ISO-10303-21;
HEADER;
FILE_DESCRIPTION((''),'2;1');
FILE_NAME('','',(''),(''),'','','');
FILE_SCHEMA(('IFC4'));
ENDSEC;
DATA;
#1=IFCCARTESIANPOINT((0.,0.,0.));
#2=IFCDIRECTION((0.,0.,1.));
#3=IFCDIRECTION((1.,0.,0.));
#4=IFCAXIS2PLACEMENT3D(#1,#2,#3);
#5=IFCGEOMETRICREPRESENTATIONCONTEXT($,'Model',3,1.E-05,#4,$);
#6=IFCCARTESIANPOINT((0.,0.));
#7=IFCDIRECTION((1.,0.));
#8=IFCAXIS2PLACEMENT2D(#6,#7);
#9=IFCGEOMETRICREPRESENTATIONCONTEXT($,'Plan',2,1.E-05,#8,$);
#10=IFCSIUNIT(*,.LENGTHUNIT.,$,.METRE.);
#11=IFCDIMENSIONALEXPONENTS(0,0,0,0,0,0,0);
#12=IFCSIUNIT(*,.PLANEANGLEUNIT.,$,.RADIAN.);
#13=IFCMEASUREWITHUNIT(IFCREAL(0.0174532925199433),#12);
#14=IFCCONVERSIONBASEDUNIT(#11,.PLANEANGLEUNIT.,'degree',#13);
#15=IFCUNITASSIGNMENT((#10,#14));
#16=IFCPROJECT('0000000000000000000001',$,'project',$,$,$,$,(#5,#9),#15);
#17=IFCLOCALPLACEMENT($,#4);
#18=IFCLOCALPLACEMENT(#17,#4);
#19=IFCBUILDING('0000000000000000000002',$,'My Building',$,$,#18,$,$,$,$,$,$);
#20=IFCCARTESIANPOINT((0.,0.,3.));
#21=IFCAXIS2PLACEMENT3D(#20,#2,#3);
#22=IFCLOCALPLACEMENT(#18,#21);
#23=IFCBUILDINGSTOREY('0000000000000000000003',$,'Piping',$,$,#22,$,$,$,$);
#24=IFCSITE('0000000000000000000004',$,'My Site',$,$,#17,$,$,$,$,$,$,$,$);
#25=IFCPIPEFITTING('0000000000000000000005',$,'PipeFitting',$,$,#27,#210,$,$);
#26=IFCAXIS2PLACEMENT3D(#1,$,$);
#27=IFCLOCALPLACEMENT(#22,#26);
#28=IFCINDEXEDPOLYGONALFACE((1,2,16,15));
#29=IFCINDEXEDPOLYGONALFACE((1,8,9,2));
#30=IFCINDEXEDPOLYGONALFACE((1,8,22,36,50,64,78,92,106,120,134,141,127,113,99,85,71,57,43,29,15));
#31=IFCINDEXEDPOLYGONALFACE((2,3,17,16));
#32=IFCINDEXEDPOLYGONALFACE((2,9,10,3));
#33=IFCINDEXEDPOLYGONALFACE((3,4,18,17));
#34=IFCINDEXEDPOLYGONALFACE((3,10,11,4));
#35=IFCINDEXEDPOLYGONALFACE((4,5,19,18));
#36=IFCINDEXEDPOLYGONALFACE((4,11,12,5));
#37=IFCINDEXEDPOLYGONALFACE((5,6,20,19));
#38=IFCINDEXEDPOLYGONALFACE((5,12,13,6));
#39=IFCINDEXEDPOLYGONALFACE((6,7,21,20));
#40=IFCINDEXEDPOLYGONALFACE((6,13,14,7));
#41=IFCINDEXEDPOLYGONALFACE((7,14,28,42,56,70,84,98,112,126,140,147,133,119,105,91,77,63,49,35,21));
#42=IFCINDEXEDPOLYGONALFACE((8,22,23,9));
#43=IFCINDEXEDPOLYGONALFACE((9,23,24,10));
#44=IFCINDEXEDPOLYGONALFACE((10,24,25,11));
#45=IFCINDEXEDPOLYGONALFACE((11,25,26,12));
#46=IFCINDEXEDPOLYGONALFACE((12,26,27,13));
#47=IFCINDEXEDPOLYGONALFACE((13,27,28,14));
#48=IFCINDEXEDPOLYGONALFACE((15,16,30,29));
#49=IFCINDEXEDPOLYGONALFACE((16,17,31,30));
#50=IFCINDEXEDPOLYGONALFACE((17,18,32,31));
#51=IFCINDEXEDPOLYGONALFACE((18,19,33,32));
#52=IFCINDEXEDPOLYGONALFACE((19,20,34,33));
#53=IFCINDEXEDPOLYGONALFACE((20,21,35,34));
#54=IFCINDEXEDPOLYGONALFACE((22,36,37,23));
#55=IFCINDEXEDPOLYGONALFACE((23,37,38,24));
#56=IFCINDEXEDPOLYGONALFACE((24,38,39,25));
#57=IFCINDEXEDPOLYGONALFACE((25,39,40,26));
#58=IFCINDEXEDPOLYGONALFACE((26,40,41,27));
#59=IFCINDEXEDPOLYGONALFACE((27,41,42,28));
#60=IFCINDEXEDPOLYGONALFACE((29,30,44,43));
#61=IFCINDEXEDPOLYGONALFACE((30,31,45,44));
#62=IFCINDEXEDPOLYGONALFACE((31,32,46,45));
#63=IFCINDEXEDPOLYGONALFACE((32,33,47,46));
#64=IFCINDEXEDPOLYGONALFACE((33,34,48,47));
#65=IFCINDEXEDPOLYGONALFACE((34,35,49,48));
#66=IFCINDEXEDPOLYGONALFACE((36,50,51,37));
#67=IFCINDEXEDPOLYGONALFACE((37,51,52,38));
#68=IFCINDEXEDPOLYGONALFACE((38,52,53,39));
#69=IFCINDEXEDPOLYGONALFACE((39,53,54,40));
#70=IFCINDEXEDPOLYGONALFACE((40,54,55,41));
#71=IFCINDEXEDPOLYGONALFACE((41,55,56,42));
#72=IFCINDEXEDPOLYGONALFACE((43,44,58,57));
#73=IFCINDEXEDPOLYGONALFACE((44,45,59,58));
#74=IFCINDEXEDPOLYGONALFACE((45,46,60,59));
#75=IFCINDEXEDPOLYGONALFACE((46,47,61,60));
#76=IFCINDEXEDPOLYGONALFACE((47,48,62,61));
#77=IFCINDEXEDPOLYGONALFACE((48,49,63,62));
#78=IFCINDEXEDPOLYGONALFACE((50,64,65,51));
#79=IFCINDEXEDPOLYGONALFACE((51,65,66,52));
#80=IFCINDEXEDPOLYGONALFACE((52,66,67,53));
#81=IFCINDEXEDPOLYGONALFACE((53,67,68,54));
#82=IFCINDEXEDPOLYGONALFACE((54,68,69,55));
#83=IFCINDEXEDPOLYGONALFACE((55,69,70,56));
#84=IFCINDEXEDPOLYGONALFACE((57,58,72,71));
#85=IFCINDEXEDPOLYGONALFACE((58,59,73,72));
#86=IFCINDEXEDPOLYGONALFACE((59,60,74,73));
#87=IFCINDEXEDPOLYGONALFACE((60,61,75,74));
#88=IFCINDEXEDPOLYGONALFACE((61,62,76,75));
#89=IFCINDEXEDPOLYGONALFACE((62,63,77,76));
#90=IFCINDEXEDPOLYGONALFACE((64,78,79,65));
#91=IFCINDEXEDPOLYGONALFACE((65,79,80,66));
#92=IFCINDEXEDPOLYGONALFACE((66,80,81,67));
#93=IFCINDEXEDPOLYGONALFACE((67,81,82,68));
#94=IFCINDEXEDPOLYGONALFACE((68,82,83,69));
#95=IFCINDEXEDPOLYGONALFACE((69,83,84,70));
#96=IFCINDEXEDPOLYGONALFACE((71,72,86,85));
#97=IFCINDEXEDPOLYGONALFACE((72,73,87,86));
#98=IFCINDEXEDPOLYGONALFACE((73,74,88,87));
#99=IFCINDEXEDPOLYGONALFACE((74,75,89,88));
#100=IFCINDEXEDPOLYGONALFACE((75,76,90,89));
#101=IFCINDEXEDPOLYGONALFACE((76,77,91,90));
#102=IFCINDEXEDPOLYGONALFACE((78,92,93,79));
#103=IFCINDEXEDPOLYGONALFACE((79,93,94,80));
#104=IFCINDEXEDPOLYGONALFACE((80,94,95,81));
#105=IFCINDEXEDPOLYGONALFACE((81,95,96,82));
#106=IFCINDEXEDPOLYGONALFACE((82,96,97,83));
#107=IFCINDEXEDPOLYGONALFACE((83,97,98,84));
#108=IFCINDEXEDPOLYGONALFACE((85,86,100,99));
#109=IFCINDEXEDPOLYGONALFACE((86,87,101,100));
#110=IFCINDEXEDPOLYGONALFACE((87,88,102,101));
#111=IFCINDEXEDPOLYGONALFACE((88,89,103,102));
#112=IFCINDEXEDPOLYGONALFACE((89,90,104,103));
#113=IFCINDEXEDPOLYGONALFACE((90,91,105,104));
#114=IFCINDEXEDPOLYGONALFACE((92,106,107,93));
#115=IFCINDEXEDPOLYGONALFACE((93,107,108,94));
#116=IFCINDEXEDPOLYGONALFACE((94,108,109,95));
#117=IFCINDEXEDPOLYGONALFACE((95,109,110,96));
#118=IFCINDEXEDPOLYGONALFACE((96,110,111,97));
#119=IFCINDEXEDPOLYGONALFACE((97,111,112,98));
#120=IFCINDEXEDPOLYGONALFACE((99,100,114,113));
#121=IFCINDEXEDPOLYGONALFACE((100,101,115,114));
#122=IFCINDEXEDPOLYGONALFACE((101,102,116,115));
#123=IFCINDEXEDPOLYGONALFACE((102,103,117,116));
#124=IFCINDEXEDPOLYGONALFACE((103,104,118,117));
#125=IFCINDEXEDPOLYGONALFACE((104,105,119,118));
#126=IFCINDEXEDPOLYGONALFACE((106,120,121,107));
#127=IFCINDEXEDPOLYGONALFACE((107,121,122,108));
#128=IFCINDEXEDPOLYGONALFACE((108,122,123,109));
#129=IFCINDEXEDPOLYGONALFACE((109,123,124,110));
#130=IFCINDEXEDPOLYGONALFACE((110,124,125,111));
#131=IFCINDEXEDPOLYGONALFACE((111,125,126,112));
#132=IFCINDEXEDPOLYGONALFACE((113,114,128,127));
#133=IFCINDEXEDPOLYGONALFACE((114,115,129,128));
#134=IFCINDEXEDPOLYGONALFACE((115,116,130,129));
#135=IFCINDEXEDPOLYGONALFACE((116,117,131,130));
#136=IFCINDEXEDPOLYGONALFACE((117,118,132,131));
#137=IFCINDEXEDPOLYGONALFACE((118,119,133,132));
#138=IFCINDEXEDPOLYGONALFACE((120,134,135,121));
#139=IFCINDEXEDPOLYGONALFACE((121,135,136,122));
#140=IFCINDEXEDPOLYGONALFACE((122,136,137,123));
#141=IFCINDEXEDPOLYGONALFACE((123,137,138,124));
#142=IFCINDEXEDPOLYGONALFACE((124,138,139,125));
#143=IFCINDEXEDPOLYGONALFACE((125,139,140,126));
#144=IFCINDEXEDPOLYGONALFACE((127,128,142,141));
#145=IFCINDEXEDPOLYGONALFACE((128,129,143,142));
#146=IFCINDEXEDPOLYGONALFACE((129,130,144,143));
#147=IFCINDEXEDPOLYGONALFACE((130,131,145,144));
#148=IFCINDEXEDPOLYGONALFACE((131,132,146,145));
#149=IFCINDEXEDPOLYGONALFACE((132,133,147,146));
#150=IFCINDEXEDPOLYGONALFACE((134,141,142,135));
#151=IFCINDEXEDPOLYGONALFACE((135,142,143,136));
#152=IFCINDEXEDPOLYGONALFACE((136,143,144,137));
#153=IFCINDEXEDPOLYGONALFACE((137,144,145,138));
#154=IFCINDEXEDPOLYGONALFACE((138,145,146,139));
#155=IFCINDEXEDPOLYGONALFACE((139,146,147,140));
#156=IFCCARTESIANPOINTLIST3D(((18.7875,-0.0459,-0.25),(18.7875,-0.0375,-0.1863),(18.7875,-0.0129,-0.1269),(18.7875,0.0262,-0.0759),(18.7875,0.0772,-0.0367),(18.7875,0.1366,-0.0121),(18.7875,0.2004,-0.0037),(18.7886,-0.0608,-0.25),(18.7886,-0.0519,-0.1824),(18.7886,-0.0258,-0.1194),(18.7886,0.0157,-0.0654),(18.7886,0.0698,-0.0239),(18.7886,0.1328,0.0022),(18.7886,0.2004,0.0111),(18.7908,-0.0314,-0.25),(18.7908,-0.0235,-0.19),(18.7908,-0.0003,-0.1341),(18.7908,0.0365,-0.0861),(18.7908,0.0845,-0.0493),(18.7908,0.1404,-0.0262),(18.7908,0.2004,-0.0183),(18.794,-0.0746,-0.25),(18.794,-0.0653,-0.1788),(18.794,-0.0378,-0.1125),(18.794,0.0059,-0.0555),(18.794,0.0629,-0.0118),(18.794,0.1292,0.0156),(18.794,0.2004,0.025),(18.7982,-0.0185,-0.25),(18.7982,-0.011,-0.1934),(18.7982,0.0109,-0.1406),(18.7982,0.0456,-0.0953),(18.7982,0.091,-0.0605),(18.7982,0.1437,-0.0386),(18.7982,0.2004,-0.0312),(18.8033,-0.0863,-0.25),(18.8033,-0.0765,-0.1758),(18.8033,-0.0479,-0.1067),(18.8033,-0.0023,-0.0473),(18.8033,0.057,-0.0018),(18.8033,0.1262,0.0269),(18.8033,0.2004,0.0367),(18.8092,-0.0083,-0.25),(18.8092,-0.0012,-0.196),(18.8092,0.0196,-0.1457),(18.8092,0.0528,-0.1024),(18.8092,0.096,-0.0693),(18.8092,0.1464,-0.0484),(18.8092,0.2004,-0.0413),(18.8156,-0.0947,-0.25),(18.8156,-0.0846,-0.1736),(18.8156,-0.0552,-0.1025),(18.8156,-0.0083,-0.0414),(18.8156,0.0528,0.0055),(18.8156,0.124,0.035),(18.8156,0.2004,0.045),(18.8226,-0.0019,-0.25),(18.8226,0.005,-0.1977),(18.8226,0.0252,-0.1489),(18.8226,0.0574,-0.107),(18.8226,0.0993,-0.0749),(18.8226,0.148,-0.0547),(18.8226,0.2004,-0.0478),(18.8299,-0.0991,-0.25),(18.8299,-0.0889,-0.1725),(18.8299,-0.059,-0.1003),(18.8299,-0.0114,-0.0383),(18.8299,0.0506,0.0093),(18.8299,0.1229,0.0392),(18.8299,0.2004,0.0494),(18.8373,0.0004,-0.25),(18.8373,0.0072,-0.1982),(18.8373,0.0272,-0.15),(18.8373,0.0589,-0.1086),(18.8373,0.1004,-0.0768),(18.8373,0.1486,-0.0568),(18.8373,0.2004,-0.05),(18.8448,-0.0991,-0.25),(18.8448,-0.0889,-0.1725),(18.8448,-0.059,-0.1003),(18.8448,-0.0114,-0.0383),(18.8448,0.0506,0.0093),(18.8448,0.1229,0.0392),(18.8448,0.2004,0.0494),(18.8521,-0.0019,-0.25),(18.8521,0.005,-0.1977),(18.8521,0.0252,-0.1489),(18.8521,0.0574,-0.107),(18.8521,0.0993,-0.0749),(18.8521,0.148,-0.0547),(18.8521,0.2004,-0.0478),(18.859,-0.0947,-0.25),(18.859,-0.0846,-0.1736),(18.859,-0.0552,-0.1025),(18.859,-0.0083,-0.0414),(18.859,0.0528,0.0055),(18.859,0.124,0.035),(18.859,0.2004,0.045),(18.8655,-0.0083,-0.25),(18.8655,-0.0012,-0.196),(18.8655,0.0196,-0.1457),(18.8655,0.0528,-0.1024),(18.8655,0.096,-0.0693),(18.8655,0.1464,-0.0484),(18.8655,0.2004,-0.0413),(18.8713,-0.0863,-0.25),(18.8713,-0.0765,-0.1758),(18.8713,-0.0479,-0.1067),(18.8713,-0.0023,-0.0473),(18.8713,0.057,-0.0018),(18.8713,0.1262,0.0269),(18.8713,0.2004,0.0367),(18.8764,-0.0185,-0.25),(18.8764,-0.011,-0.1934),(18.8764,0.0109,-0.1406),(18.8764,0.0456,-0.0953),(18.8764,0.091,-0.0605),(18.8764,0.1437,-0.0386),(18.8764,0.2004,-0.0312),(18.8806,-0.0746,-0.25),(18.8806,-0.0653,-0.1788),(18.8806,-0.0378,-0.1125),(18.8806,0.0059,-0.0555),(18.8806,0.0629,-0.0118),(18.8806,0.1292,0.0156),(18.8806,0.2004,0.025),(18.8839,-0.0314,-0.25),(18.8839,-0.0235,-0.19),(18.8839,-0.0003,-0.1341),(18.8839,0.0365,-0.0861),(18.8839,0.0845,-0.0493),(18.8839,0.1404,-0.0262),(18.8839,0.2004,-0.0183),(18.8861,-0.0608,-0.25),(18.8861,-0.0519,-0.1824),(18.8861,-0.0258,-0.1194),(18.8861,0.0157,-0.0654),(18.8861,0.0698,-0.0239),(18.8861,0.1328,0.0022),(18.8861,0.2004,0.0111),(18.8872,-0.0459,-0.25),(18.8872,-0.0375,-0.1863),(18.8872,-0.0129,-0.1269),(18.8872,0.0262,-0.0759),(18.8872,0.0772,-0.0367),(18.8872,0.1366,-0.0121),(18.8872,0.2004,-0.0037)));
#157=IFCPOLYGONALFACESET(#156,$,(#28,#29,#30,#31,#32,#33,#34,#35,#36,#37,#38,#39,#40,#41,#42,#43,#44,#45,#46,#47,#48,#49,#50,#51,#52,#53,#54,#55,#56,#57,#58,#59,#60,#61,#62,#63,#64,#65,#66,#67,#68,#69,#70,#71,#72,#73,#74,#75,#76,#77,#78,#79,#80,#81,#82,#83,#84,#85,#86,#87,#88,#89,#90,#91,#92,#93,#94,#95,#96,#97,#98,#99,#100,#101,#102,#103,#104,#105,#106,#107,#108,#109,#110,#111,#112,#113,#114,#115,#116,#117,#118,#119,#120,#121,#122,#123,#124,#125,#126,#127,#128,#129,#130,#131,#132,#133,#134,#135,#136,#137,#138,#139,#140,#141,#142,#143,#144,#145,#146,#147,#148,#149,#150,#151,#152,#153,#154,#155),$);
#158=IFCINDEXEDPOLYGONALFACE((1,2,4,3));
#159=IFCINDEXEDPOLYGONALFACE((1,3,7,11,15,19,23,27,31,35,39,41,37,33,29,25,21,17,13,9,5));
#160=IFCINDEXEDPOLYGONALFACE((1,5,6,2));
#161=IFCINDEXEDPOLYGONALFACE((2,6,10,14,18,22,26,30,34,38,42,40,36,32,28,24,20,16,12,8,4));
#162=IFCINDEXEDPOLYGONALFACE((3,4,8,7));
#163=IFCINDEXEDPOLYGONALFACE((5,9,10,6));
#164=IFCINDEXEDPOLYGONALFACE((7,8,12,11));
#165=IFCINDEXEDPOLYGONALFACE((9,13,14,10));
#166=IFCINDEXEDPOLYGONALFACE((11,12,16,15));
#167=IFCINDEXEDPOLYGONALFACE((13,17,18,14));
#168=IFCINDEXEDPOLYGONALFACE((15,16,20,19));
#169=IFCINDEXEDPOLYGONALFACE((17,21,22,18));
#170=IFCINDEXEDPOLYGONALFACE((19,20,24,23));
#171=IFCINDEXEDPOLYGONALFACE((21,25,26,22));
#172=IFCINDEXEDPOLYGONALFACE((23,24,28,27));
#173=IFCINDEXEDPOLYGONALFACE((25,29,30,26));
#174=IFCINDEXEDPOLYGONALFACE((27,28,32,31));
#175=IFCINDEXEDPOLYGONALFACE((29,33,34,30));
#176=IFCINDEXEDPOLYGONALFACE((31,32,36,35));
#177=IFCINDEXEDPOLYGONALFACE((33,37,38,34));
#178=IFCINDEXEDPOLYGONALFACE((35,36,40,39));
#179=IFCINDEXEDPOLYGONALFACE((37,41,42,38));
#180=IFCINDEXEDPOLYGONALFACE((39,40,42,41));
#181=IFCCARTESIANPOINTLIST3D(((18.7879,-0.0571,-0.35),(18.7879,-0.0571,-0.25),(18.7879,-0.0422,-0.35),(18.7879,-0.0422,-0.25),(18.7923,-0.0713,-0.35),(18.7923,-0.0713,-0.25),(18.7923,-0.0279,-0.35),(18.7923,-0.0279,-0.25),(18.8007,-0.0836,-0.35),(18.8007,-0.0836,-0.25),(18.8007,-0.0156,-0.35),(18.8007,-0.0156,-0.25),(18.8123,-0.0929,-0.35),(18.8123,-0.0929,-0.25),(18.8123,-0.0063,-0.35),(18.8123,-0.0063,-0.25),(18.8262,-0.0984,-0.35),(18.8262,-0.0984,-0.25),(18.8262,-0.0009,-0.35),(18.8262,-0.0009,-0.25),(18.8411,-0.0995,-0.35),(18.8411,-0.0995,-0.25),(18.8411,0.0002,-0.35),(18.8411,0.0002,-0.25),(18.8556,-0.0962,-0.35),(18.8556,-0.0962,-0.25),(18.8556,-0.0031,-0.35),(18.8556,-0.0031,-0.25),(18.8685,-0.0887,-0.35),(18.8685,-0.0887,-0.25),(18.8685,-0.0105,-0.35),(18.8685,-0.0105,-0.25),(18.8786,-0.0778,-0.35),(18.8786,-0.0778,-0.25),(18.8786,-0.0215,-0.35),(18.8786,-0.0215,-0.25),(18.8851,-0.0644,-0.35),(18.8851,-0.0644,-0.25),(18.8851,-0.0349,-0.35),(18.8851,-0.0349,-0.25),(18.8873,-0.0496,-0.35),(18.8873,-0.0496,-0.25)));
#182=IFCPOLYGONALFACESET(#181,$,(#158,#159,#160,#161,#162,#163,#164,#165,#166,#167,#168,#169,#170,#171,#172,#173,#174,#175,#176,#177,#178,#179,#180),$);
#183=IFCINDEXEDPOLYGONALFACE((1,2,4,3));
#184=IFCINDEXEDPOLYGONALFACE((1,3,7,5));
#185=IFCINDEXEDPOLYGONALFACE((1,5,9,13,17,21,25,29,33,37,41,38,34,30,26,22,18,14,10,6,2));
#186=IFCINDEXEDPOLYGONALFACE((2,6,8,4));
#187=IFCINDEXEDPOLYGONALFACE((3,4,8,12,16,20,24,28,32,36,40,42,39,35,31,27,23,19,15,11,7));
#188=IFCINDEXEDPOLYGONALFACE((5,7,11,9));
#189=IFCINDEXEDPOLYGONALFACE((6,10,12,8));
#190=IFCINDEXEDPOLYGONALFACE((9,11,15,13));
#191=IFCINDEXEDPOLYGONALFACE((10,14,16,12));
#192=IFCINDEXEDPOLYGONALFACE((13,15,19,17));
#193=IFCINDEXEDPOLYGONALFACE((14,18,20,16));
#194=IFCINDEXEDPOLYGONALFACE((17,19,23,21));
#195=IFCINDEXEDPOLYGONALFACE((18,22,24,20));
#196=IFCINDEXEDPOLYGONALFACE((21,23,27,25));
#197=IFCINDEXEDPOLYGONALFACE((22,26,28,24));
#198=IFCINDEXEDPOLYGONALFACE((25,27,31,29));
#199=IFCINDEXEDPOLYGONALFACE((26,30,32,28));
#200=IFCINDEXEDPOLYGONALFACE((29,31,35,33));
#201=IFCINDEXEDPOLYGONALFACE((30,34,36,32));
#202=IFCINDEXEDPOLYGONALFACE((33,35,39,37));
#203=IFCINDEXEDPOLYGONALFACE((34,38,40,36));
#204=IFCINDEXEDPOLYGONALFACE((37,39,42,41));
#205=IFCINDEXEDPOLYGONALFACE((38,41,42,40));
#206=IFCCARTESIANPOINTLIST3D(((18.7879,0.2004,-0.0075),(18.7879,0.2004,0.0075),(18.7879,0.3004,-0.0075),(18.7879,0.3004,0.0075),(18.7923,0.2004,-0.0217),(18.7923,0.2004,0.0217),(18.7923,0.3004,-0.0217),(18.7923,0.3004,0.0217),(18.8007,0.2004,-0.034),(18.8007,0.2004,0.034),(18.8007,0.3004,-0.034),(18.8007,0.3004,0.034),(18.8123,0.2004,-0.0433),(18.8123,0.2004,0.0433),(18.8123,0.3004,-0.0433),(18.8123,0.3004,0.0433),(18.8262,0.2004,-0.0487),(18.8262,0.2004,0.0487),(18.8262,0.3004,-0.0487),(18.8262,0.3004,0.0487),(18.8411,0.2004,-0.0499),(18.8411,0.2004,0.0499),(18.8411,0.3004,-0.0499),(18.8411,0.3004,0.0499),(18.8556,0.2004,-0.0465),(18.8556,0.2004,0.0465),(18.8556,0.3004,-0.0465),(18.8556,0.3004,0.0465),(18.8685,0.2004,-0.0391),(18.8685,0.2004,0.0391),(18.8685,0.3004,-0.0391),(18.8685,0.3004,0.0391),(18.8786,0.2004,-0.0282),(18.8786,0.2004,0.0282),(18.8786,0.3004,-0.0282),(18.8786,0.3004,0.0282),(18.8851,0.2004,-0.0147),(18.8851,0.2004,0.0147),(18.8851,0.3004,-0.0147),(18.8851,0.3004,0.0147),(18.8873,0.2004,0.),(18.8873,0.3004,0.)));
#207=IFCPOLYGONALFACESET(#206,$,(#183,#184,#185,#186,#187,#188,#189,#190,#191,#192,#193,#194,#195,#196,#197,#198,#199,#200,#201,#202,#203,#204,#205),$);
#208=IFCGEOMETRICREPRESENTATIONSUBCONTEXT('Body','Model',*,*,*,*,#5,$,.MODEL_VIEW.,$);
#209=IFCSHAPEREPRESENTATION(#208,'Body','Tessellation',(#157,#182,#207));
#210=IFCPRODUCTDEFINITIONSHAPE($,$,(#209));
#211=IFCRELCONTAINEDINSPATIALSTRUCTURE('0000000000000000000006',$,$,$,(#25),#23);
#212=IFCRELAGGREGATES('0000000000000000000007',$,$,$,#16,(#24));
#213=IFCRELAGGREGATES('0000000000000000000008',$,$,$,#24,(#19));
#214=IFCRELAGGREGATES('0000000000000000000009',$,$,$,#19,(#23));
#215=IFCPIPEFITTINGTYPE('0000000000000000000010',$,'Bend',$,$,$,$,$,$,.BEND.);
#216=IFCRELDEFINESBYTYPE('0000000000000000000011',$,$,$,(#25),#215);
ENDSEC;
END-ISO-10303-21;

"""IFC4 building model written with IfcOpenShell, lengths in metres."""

from ifc_helpers import new_model, entity, si_unit, converted_unit, frame, origin_with_axes, origin_2d_with_axis, place, context, subcontext, project, spatial, circle, extrude, source, transform, mapped, type_object, type_shapes, element, save


model = new_model("IFC4")

# Units and contexts
model_context = context("Model", 3, precision=1e-05, world=origin_with_axes())
plan_context = context("Plan", 2, precision=1e-05, world=origin_2d_with_axis())
body_context = subcontext(model_context, "Body", "Model", "MODEL_VIEW")
ifc_project = project(units=[si_unit("LENGTHUNIT", "METRE"), converted_unit("PLANEANGLEUNIT", "degree", entity("IfcReal", 0.0174532925199433), si_unit("PLANEANGLEUNIT", "RADIAN"), dimensions=[0, 0, 0, 0, 0, 0, 0])], contexts=[model_context, plan_context])

# Site, building, storey
site_placement = place(None, origin_with_axes())
site = spatial("IfcSite", under=ifc_project, at=site_placement, Name="My Site")
building_placement = place(site_placement, origin_with_axes())
building = spatial("IfcBuilding", under=site, at=building_placement, Name="My Building")
storey_placement = place(building_placement, frame((0.0, 0.0, 3.0), z_axis=(0.0, 0.0, 1.0), x_axis=(1.0, 0.0, 0.0)))
storey = spatial("IfcBuildingStorey", under=building, at=storey_placement, Name="Piping")

# Pipe fitting
pipe_fitting_type = type_object("IfcPipeFittingType", Name="Bend", PredefinedType="BEND")
shared_shape = source(origin_with_axes(), body_context, "Body", "SolidModel", [
    entity("IfcSweptDiskSolid", entity("IfcIndexedPolyCurve", entity("IfcCartesianPointList3D", [[0.0, 0.0, -0.1], [0.0, -0.0732, -0.2768], [0.0, -0.25, -0.35]]), [entity("IfcArcIndex", [1, 2, 3])]), 0.05),
    extrude(circle(Radius=0.05), origin_with_axes(), (0.0, 0.0, -1.0), 0.1),
    extrude(circle(Radius=0.05), frame((0.0, -0.25, -0.35), z_axis=(0.0, -1.0, 0.0), x_axis=(1.0, 0.0, 0.0)), (0.0, 0.0, 1.0), 0.1),
])
type_shapes(pipe_fitting_type, [shared_shape])
for number, where, z_axis, x_axis, name in (
    (1, (18.8373, -0.0496, -0.35), (0.0, 0.0, -1.0), (1.0, 0.0, 0.0), "PipeFitting"),
):
    element("IfcPipeFitting", number, at=place(storey_placement, frame(where, z_axis=z_axis, x_axis=x_axis)), inside=storey, type_object=pipe_fitting_type, Name=name, context=body_context, shape_type="MappedRepresentation", body=[
        mapped(shared_shape, transform((0.0, 0.0, 0.0), x_axis=(1.0, 0.0, 0.0), y_axis=(0.0, 1.0, 0.0), z_axis=(0.0, 0.0, 1.0), scale=1.0)),
    ])

save(model, "model.ifc")
